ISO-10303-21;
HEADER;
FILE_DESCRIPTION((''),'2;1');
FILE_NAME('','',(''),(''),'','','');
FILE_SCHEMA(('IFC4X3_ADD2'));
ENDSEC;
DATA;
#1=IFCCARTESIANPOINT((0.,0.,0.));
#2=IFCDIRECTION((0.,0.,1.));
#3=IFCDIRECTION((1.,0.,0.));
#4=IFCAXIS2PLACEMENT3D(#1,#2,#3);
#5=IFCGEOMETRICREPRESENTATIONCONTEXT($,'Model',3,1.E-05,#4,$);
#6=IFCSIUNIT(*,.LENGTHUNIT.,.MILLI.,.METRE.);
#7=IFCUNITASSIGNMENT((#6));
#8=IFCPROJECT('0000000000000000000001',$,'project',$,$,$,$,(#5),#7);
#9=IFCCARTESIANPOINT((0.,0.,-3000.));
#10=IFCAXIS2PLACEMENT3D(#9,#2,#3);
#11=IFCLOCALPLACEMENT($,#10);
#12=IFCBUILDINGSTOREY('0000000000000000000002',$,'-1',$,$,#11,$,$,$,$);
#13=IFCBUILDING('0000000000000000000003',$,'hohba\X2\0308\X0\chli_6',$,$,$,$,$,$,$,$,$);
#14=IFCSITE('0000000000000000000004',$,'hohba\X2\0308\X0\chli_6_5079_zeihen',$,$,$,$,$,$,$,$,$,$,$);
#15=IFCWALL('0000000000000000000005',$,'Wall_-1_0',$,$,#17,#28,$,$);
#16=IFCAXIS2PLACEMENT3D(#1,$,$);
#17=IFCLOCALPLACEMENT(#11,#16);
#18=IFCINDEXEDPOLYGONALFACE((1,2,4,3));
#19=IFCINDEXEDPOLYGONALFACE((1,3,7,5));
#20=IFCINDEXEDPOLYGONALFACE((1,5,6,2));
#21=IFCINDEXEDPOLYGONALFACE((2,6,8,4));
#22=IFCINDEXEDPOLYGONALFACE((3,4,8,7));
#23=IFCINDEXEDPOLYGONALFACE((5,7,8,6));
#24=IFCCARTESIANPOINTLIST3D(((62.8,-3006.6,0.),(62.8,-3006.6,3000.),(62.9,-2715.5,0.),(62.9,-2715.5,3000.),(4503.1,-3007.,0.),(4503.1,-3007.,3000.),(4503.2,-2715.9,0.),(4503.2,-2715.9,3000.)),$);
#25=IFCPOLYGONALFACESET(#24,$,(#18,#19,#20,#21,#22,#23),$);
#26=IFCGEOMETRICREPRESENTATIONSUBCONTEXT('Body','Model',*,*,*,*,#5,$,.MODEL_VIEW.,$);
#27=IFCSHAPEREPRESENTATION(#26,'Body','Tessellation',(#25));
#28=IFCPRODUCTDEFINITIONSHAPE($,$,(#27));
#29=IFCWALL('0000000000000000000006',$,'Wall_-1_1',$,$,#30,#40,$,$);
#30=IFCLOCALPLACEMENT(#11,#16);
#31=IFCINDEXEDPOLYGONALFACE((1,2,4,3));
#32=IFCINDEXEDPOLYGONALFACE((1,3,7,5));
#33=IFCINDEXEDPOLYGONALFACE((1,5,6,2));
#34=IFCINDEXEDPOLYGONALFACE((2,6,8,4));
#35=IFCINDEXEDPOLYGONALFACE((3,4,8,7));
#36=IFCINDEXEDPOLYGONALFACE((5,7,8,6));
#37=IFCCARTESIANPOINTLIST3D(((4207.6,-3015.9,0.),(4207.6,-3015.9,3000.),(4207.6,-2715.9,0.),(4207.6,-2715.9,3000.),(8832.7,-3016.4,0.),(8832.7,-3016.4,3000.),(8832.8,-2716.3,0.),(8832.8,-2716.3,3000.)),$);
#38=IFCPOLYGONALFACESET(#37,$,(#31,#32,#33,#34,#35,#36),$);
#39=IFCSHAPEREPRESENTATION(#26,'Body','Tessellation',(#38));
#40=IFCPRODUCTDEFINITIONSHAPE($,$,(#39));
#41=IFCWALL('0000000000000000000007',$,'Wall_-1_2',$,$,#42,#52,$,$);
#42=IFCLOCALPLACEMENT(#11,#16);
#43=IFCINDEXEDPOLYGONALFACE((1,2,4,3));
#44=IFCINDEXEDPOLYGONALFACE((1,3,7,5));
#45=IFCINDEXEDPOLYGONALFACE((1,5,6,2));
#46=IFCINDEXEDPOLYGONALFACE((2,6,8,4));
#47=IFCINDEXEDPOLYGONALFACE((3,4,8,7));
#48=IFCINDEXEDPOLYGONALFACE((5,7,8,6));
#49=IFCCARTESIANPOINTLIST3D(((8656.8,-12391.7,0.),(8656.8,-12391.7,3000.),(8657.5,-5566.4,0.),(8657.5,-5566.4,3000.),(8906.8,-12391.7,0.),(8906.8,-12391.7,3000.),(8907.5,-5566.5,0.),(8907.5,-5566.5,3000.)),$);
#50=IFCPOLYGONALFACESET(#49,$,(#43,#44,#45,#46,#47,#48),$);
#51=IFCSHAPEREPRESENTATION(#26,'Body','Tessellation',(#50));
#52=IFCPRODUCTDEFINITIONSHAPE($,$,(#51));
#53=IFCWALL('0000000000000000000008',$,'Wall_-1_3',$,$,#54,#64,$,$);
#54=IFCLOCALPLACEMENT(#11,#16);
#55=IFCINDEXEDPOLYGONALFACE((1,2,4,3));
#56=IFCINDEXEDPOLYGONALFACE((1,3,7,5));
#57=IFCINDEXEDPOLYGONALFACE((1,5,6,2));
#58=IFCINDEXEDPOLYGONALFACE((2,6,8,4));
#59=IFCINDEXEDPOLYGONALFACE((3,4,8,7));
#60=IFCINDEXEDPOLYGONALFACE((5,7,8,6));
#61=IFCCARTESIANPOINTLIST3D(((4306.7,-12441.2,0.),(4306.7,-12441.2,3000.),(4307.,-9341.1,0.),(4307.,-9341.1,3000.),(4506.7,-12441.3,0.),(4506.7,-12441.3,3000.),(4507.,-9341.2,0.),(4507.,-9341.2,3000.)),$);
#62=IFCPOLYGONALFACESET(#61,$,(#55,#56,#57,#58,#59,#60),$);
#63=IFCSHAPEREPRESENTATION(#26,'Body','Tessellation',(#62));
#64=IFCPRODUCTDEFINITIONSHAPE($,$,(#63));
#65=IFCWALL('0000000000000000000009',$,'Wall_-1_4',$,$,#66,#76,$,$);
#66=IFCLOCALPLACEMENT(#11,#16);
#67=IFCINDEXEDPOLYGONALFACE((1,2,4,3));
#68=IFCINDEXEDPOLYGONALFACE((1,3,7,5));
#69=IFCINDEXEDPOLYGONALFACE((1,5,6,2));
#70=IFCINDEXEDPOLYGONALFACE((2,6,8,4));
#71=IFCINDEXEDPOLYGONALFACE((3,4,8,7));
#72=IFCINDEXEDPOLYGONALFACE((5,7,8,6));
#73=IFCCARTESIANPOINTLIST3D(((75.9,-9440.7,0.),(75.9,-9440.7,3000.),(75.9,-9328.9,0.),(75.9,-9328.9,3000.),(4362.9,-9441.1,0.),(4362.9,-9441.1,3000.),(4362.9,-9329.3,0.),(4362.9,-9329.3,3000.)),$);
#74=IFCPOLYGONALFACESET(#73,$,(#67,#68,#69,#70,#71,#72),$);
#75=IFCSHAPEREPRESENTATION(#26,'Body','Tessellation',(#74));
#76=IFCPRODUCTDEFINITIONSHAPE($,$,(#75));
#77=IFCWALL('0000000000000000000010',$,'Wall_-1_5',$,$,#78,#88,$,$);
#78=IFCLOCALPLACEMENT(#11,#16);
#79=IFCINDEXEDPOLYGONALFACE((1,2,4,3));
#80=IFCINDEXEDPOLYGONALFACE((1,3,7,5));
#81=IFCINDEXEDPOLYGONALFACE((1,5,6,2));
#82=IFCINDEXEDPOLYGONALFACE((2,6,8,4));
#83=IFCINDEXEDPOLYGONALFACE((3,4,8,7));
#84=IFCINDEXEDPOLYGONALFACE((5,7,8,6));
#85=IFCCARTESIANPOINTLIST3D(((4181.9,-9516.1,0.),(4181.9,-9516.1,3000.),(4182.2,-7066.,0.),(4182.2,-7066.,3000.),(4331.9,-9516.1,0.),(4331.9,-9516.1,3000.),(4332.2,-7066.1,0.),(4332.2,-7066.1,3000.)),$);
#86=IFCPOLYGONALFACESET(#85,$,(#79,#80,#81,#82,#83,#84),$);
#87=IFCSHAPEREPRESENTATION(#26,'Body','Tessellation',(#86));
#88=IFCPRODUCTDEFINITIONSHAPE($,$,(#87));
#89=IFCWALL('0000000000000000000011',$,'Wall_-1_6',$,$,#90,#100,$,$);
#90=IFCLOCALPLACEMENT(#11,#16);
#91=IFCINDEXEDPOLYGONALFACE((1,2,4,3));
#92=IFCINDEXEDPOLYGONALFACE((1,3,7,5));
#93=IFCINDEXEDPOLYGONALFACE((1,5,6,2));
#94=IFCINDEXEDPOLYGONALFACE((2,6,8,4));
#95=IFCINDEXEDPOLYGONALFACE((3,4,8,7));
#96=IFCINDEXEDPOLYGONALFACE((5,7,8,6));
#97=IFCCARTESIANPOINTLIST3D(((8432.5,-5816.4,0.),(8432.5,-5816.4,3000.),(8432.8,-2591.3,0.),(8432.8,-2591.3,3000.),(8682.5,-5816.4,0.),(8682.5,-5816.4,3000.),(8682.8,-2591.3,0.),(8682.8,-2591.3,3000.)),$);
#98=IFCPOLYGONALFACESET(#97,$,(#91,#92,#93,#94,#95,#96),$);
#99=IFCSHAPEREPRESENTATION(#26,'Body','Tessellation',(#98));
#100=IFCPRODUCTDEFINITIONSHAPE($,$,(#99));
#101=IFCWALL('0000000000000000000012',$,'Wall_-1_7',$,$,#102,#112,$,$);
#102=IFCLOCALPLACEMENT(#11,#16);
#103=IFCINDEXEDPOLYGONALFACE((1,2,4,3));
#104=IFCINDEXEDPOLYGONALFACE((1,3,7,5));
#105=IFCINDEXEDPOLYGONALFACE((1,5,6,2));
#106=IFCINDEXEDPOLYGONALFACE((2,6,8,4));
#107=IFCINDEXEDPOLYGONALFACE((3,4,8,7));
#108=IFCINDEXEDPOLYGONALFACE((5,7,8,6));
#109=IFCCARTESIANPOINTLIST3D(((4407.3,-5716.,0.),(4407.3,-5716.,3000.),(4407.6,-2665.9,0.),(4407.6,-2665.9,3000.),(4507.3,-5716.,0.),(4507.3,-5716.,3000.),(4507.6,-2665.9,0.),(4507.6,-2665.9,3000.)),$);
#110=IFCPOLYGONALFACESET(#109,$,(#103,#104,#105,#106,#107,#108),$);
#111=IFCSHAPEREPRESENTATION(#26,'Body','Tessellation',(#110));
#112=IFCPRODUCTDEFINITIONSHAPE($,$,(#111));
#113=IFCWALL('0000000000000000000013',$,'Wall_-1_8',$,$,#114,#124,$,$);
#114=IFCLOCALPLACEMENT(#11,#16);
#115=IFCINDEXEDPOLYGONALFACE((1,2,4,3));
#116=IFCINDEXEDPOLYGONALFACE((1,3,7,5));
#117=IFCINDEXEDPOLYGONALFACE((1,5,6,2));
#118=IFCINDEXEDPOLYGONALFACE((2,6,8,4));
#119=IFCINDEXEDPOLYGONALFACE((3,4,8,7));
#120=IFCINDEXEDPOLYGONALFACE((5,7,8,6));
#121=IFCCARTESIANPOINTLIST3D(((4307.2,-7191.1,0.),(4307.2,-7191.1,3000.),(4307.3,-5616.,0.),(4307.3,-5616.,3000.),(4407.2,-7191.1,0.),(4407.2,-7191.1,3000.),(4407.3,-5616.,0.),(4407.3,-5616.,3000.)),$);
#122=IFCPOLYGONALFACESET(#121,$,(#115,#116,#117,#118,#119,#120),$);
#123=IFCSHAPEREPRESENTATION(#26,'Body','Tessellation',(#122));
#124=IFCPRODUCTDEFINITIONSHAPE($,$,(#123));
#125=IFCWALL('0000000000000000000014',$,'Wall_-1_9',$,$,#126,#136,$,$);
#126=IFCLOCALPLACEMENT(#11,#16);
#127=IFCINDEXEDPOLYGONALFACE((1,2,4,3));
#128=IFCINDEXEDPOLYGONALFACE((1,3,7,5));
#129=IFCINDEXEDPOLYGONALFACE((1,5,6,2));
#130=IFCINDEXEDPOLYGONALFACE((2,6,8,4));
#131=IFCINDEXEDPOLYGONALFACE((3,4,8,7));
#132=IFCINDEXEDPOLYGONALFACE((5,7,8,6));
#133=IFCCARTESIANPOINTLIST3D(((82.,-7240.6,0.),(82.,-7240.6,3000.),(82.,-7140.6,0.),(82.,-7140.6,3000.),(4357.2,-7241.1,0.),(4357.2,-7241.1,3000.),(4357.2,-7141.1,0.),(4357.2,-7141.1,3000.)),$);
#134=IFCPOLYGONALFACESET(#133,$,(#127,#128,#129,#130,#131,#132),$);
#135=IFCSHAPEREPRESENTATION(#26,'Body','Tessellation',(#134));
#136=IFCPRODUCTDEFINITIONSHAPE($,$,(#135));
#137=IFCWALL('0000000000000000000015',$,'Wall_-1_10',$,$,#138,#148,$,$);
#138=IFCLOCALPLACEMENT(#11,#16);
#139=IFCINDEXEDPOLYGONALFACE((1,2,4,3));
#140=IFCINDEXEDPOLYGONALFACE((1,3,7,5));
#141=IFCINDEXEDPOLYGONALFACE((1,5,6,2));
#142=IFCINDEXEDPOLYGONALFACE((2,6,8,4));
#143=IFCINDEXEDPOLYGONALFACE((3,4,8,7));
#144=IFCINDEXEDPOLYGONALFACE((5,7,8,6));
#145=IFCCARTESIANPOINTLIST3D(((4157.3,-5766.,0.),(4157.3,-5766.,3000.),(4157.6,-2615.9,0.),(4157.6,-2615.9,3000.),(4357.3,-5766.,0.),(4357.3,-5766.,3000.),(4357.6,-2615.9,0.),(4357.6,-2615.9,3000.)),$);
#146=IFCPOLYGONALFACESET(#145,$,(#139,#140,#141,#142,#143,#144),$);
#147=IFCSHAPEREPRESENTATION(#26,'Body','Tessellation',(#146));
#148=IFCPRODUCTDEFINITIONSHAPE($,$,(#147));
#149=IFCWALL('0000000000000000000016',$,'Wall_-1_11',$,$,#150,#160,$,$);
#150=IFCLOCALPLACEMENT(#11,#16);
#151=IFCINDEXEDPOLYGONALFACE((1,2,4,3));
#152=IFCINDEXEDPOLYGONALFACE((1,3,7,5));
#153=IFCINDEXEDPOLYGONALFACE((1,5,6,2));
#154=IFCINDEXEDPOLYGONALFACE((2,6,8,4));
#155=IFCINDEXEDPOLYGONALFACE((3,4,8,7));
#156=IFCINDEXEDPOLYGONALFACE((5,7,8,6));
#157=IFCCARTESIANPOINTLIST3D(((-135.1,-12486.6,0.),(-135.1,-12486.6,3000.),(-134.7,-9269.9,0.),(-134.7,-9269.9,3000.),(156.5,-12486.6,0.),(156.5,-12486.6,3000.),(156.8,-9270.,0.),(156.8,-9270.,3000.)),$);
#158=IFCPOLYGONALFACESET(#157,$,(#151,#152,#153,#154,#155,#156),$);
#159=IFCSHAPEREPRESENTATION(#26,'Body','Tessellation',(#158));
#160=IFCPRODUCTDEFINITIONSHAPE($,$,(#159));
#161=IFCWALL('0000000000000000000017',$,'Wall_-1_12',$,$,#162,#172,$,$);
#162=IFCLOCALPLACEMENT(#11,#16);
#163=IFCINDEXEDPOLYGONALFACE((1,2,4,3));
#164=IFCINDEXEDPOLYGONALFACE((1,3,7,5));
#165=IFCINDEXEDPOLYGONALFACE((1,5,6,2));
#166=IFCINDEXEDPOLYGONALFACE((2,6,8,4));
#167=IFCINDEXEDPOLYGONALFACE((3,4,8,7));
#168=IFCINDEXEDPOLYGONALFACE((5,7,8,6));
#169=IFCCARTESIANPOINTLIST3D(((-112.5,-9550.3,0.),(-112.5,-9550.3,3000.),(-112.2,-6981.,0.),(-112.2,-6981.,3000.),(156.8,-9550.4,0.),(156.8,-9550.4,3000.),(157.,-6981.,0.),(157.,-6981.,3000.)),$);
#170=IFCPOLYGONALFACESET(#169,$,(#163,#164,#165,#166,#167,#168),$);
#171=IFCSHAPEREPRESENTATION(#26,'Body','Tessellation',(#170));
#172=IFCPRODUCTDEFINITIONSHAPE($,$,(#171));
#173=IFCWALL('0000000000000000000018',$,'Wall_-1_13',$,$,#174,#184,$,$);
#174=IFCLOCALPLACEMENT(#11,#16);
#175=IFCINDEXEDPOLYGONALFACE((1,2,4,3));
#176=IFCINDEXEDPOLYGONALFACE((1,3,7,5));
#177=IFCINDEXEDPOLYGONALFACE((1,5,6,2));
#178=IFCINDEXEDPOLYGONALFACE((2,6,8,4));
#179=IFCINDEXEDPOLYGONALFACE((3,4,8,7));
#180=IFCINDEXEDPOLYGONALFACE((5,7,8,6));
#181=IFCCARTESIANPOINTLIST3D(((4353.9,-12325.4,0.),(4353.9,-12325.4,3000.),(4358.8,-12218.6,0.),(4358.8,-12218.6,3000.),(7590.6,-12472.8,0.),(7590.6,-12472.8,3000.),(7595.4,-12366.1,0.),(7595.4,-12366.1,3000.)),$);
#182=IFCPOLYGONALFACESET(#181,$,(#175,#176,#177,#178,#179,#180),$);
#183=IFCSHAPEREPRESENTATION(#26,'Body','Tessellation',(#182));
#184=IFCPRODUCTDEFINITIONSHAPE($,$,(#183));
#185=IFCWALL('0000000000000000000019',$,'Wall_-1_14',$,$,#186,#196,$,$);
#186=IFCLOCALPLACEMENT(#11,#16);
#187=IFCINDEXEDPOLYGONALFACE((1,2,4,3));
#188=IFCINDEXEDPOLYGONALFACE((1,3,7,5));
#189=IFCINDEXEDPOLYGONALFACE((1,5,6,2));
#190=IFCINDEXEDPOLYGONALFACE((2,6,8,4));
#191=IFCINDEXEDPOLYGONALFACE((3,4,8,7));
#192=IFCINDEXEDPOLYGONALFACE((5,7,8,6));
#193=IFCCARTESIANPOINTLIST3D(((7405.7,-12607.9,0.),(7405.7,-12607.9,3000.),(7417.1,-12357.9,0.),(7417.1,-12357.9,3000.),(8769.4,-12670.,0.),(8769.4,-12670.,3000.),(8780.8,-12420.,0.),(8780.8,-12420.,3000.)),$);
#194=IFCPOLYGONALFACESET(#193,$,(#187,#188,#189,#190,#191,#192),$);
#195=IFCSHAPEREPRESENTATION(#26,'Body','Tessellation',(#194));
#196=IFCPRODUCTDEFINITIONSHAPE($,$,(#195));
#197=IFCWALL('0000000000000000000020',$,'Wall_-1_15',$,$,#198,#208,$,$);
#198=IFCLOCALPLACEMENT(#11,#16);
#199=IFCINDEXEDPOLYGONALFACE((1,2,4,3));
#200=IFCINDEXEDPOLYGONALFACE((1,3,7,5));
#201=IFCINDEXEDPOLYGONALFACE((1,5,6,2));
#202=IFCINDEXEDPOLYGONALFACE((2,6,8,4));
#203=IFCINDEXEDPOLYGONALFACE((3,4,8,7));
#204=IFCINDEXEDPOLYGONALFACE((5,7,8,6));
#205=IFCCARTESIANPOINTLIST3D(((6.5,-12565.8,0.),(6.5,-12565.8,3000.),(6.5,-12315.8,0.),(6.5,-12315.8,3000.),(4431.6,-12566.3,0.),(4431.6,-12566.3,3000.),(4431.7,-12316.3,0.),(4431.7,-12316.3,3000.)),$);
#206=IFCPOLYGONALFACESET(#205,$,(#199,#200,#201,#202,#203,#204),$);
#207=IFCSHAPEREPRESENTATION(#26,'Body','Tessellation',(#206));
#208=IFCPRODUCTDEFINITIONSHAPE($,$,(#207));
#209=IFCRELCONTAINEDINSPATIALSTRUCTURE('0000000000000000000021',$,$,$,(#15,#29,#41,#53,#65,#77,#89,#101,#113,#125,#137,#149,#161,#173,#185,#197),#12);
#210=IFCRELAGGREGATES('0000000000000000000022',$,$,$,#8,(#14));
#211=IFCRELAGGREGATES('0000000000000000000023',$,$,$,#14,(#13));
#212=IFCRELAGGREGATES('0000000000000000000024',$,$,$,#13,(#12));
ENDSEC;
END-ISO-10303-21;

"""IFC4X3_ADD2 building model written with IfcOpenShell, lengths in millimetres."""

from ifc_helpers import new_model, si_unit, frame, origin_with_axes, place, context, subcontext, project, spatial, indexed_curve, outline, extrude, element, save


model = new_model("IFC4X3_ADD2")

# Units and contexts
model_context = context("Model", 3, precision=1e-05, world=origin_with_axes())
body_context = subcontext(model_context, "Body", "Model", "MODEL_VIEW")
ifc_project = project(units=[si_unit("LENGTHUNIT", "METRE", prefix="MILLI")], contexts=[model_context])

# Site, building, storey
site = spatial("IfcSite", under=ifc_project, Name="hohbächli_6_5079_zeihen")
building = spatial("IfcBuilding", under=site, Name="hohbächli_6")
storey_placement = place(None, frame((0.0, 0.0, -3000.0), z_axis=(0.0, 0.0, 1.0), x_axis=(1.0, 0.0, 0.0)))
storey = spatial("IfcBuildingStorey", under=building, at=storey_placement, Name="-1")

# Walls
wall_1_placement = place(storey_placement, frame((4503.2, -2715.9, 0.0), z_axis=(0.0, 0.0, 1.0), x_axis=(-1.0, 0.000098, 0.0)))
element("IfcWall", 1, at=wall_1_placement, inside=storey, Name="Wall_-1_0", context=body_context, shape_type="SweptSolid", body=[
    extrude(outline(indexed_curve([(0.0, 0.0), (0.0, 291.1), (4440.3, 291.1), (4440.3, 0.0), (0.0, 0.0)], self_intersect=False)), origin_with_axes(), (0.0, 0.0, 1.0), 3000.0),
])
wall_2_placement = place(storey_placement, frame((8832.8, -2716.3, 0.0), z_axis=(0.0, 0.0, 1.0), x_axis=(-1.0, 0.000098, 0.0)))
element("IfcWall", 2, at=wall_2_placement, inside=storey, Name="Wall_-1_1", context=body_context, shape_type="SweptSolid", body=[
    extrude(outline(indexed_curve([(0.0, 0.0), (0.0, 300.0), (4625.2, 300.0), (4625.2, 0.0), (0.0, 0.0)], self_intersect=False)), origin_with_axes(), (0.0, 0.0, 1.0), 3000.0),
])
wall_3_placement = place(storey_placement, frame((8657.5, -5566.4, 0.0), z_axis=(0.0, 0.0, 1.0), x_axis=(-0.000098, -1.0, 0.0)))
element("IfcWall", 3, at=wall_3_placement, inside=storey, Name="Wall_-1_2", context=body_context, shape_type="SweptSolid", body=[
    extrude(outline(indexed_curve([(0.0, 0.0), (0.0, 250.0), (6825.2, 250.0), (6825.2, 0.0), (0.0, 0.0)], self_intersect=False)), origin_with_axes(), (0.0, 0.0, 1.0), 3000.0),
])
wall_4_placement = place(storey_placement, frame((4307.0, -9341.1, 0.0), z_axis=(0.0, 0.0, 1.0), x_axis=(-0.000098, -1.0, 0.0)))
element("IfcWall", 4, at=wall_4_placement, inside=storey, Name="Wall_-1_3", context=body_context, shape_type="SweptSolid", body=[
    extrude(outline(indexed_curve([(0.0, 0.0), (0.0, 200.0), (3100.1, 200.0), (3100.1, 0.0), (0.0, 0.0)], self_intersect=False)), origin_with_axes(), (0.0, 0.0, 1.0), 3000.0),
])
wall_5_placement = place(storey_placement, frame((75.9, -9440.7, 0.0), z_axis=(0.0, 0.0, 1.0), x_axis=(1.0, -0.000098, 0.0)))
element("IfcWall", 5, at=wall_5_placement, inside=storey, Name="Wall_-1_4", context=body_context, shape_type="SweptSolid", body=[
    extrude(outline(indexed_curve([(0.0, 0.0), (0.0, 111.8), (4287.0, 111.8), (4287.0, 0.0), (0.0, 0.0)], self_intersect=False)), origin_with_axes(), (0.0, 0.0, 1.0), 3000.0),
])
wall_6_placement = place(storey_placement, frame((4331.9, -9516.1, 0.0), z_axis=(0.0, 0.0, 1.0), x_axis=(0.000098, 1.0, 0.0)))
element("IfcWall", 6, at=wall_6_placement, inside=storey, Name="Wall_-1_5", context=body_context, shape_type="SweptSolid", body=[
    extrude(outline(indexed_curve([(0.0, 0.0), (0.0, 150.0), (2450.1, 150.0), (2450.1, 0.0), (0.0, 0.0)], self_intersect=False)), origin_with_axes(), (0.0, 0.0, 1.0), 3000.0),
])
wall_7_placement = place(storey_placement, frame((8682.5, -5816.4, 0.0), z_axis=(0.0, 0.0, 1.0), x_axis=(0.000098, 1.0, 0.0)))
element("IfcWall", 7, at=wall_7_placement, inside=storey, Name="Wall_-1_6", context=body_context, shape_type="SweptSolid", body=[
    extrude(outline(indexed_curve([(0.0, 0.0), (0.0, 250.0), (3225.1, 250.0), (3225.1, 0.0), (0.0, 0.0)], self_intersect=False)), origin_with_axes(), (0.0, 0.0, 1.0), 3000.0),
])
wall_8_placement = place(storey_placement, frame((4407.6, -2665.9, 0.0), z_axis=(0.0, 0.0, 1.0), x_axis=(-0.000098, -1.0, 0.0)))
element("IfcWall", 8, at=wall_8_placement, inside=storey, Name="Wall_-1_7", context=body_context, shape_type="SweptSolid", body=[
    extrude(outline(indexed_curve([(0.0, 0.0), (0.0, 100.0), (3050.1, 100.0), (3050.1, 0.0), (0.0, 0.0)], self_intersect=False)), origin_with_axes(), (0.0, 0.0, 1.0), 3000.0),
])
wall_9_placement = place(storey_placement, frame((4407.2, -7191.1, 0.0), z_axis=(0.0, 0.0, 1.0), x_axis=(0.000098, 1.0, 0.0)))
element("IfcWall", 9, at=wall_9_placement, inside=storey, Name="Wall_-1_8", context=body_context, shape_type="SweptSolid", body=[
    extrude(outline(indexed_curve([(0.0, 0.0), (0.0, 100.0), (1575.1, 100.0), (1575.1, 0.0), (0.0, 0.0)], self_intersect=False)), origin_with_axes(), (0.0, 0.0, 1.0), 3000.0),
])
wall_10_placement = place(storey_placement, frame((4357.2, -7141.1, 0.0), z_axis=(0.0, 0.0, 1.0), x_axis=(-1.0, 0.000098, 0.0)))
element("IfcWall", 10, at=wall_10_placement, inside=storey, Name="Wall_-1_9", context=body_context, shape_type="SweptSolid", body=[
    extrude(outline(indexed_curve([(0.0, 0.0), (0.0, 100.0), (4275.2, 100.0), (4275.2, 0.0), (0.0, 0.0)], self_intersect=False)), origin_with_axes(), (0.0, 0.0, 1.0), 3000.0),
])
wall_11_placement = place(storey_placement, frame((4357.3, -5766.0, 0.0), z_axis=(0.0, 0.0, 1.0), x_axis=(0.000098, 1.0, 0.0)))
element("IfcWall", 11, at=wall_11_placement, inside=storey, Name="Wall_-1_10", context=body_context, shape_type="SweptSolid", body=[
    extrude(outline(indexed_curve([(0.0, 0.0), (0.0, 200.0), (3150.1, 200.0), (3150.1, 0.0), (0.0, 0.0)], self_intersect=False)), origin_with_axes(), (0.0, 0.0, 1.0), 3000.0),
])
wall_12_placement = place(storey_placement, frame((156.5, -12486.6, 0.0), z_axis=(0.0, 0.0, 1.0), x_axis=(0.000098, 1.0, 0.0)))
element("IfcWall", 12, at=wall_12_placement, inside=storey, Name="Wall_-1_11", context=body_context, shape_type="SweptSolid", body=[
    extrude(outline(indexed_curve([(0.0, 0.0), (0.0, 291.6), (3216.7, 291.6), (3216.7, 0.0), (0.0, 0.0)], self_intersect=False)), origin_with_axes(), (0.0, 0.0, 1.0), 3000.0),
])
wall_13_placement = place(storey_placement, frame((156.8, -9550.4, 0.0), z_axis=(0.0, 0.0, 1.0), x_axis=(0.000098, 1.0, 0.0)))
element("IfcWall", 13, at=wall_13_placement, inside=storey, Name="Wall_-1_12", context=body_context, shape_type="SweptSolid", body=[
    extrude(outline(indexed_curve([(0.0, 0.0), (0.0, 269.3), (2569.4, 269.3), (2569.4, 0.0), (0.0, 0.0)], self_intersect=False)), origin_with_axes(), (0.0, 0.0, 1.0), 3000.0),
])
wall_14_placement = place(storey_placement, frame((7595.4, -12366.1, 0.0), z_axis=(0.0, 0.0, 1.0), x_axis=(-0.998964, 0.045506, 0.0)))
element("IfcWall", 14, at=wall_14_placement, inside=storey, Name="Wall_-1_13", context=body_context, shape_type="SweptSolid", body=[
    extrude(outline(indexed_curve([(0.0, 0.0), (0.0, 106.9), (3240.0, 106.9), (3240.0, 0.0), (0.0, 0.0)], self_intersect=False)), origin_with_axes(), (0.0, 0.0, 1.0), 3000.0),
])
wall_15_placement = place(storey_placement, frame((8780.8, -12420.0, 0.0), z_axis=(0.0, 0.0, 1.0), x_axis=(-0.998964, 0.045506, 0.0)))
element("IfcWall", 15, at=wall_15_placement, inside=storey, Name="Wall_-1_14", context=body_context, shape_type="SweptSolid", body=[
    extrude(outline(indexed_curve([(0.0, 0.0), (0.0, 250.3), (1365.1, 250.3), (1365.1, 0.0), (0.0, 0.0)], self_intersect=False)), origin_with_axes(), (0.0, 0.0, 1.0), 3000.0),
])
wall_16_placement = place(storey_placement, frame((4431.7, -12316.3, 0.0), z_axis=(0.0, 0.0, 1.0), x_axis=(-1.0, 0.000098, 0.0)))
element("IfcWall", 16, at=wall_16_placement, inside=storey, Name="Wall_-1_15", context=body_context, shape_type="SweptSolid", body=[
    extrude(outline(indexed_curve([(0.0, 0.0), (0.0, 250.0), (4425.2, 250.0), (4425.2, 0.0), (0.0, 0.0)], self_intersect=False)), origin_with_axes(), (0.0, 0.0, 1.0), 3000.0),
])

save(model, "model.ifc")
